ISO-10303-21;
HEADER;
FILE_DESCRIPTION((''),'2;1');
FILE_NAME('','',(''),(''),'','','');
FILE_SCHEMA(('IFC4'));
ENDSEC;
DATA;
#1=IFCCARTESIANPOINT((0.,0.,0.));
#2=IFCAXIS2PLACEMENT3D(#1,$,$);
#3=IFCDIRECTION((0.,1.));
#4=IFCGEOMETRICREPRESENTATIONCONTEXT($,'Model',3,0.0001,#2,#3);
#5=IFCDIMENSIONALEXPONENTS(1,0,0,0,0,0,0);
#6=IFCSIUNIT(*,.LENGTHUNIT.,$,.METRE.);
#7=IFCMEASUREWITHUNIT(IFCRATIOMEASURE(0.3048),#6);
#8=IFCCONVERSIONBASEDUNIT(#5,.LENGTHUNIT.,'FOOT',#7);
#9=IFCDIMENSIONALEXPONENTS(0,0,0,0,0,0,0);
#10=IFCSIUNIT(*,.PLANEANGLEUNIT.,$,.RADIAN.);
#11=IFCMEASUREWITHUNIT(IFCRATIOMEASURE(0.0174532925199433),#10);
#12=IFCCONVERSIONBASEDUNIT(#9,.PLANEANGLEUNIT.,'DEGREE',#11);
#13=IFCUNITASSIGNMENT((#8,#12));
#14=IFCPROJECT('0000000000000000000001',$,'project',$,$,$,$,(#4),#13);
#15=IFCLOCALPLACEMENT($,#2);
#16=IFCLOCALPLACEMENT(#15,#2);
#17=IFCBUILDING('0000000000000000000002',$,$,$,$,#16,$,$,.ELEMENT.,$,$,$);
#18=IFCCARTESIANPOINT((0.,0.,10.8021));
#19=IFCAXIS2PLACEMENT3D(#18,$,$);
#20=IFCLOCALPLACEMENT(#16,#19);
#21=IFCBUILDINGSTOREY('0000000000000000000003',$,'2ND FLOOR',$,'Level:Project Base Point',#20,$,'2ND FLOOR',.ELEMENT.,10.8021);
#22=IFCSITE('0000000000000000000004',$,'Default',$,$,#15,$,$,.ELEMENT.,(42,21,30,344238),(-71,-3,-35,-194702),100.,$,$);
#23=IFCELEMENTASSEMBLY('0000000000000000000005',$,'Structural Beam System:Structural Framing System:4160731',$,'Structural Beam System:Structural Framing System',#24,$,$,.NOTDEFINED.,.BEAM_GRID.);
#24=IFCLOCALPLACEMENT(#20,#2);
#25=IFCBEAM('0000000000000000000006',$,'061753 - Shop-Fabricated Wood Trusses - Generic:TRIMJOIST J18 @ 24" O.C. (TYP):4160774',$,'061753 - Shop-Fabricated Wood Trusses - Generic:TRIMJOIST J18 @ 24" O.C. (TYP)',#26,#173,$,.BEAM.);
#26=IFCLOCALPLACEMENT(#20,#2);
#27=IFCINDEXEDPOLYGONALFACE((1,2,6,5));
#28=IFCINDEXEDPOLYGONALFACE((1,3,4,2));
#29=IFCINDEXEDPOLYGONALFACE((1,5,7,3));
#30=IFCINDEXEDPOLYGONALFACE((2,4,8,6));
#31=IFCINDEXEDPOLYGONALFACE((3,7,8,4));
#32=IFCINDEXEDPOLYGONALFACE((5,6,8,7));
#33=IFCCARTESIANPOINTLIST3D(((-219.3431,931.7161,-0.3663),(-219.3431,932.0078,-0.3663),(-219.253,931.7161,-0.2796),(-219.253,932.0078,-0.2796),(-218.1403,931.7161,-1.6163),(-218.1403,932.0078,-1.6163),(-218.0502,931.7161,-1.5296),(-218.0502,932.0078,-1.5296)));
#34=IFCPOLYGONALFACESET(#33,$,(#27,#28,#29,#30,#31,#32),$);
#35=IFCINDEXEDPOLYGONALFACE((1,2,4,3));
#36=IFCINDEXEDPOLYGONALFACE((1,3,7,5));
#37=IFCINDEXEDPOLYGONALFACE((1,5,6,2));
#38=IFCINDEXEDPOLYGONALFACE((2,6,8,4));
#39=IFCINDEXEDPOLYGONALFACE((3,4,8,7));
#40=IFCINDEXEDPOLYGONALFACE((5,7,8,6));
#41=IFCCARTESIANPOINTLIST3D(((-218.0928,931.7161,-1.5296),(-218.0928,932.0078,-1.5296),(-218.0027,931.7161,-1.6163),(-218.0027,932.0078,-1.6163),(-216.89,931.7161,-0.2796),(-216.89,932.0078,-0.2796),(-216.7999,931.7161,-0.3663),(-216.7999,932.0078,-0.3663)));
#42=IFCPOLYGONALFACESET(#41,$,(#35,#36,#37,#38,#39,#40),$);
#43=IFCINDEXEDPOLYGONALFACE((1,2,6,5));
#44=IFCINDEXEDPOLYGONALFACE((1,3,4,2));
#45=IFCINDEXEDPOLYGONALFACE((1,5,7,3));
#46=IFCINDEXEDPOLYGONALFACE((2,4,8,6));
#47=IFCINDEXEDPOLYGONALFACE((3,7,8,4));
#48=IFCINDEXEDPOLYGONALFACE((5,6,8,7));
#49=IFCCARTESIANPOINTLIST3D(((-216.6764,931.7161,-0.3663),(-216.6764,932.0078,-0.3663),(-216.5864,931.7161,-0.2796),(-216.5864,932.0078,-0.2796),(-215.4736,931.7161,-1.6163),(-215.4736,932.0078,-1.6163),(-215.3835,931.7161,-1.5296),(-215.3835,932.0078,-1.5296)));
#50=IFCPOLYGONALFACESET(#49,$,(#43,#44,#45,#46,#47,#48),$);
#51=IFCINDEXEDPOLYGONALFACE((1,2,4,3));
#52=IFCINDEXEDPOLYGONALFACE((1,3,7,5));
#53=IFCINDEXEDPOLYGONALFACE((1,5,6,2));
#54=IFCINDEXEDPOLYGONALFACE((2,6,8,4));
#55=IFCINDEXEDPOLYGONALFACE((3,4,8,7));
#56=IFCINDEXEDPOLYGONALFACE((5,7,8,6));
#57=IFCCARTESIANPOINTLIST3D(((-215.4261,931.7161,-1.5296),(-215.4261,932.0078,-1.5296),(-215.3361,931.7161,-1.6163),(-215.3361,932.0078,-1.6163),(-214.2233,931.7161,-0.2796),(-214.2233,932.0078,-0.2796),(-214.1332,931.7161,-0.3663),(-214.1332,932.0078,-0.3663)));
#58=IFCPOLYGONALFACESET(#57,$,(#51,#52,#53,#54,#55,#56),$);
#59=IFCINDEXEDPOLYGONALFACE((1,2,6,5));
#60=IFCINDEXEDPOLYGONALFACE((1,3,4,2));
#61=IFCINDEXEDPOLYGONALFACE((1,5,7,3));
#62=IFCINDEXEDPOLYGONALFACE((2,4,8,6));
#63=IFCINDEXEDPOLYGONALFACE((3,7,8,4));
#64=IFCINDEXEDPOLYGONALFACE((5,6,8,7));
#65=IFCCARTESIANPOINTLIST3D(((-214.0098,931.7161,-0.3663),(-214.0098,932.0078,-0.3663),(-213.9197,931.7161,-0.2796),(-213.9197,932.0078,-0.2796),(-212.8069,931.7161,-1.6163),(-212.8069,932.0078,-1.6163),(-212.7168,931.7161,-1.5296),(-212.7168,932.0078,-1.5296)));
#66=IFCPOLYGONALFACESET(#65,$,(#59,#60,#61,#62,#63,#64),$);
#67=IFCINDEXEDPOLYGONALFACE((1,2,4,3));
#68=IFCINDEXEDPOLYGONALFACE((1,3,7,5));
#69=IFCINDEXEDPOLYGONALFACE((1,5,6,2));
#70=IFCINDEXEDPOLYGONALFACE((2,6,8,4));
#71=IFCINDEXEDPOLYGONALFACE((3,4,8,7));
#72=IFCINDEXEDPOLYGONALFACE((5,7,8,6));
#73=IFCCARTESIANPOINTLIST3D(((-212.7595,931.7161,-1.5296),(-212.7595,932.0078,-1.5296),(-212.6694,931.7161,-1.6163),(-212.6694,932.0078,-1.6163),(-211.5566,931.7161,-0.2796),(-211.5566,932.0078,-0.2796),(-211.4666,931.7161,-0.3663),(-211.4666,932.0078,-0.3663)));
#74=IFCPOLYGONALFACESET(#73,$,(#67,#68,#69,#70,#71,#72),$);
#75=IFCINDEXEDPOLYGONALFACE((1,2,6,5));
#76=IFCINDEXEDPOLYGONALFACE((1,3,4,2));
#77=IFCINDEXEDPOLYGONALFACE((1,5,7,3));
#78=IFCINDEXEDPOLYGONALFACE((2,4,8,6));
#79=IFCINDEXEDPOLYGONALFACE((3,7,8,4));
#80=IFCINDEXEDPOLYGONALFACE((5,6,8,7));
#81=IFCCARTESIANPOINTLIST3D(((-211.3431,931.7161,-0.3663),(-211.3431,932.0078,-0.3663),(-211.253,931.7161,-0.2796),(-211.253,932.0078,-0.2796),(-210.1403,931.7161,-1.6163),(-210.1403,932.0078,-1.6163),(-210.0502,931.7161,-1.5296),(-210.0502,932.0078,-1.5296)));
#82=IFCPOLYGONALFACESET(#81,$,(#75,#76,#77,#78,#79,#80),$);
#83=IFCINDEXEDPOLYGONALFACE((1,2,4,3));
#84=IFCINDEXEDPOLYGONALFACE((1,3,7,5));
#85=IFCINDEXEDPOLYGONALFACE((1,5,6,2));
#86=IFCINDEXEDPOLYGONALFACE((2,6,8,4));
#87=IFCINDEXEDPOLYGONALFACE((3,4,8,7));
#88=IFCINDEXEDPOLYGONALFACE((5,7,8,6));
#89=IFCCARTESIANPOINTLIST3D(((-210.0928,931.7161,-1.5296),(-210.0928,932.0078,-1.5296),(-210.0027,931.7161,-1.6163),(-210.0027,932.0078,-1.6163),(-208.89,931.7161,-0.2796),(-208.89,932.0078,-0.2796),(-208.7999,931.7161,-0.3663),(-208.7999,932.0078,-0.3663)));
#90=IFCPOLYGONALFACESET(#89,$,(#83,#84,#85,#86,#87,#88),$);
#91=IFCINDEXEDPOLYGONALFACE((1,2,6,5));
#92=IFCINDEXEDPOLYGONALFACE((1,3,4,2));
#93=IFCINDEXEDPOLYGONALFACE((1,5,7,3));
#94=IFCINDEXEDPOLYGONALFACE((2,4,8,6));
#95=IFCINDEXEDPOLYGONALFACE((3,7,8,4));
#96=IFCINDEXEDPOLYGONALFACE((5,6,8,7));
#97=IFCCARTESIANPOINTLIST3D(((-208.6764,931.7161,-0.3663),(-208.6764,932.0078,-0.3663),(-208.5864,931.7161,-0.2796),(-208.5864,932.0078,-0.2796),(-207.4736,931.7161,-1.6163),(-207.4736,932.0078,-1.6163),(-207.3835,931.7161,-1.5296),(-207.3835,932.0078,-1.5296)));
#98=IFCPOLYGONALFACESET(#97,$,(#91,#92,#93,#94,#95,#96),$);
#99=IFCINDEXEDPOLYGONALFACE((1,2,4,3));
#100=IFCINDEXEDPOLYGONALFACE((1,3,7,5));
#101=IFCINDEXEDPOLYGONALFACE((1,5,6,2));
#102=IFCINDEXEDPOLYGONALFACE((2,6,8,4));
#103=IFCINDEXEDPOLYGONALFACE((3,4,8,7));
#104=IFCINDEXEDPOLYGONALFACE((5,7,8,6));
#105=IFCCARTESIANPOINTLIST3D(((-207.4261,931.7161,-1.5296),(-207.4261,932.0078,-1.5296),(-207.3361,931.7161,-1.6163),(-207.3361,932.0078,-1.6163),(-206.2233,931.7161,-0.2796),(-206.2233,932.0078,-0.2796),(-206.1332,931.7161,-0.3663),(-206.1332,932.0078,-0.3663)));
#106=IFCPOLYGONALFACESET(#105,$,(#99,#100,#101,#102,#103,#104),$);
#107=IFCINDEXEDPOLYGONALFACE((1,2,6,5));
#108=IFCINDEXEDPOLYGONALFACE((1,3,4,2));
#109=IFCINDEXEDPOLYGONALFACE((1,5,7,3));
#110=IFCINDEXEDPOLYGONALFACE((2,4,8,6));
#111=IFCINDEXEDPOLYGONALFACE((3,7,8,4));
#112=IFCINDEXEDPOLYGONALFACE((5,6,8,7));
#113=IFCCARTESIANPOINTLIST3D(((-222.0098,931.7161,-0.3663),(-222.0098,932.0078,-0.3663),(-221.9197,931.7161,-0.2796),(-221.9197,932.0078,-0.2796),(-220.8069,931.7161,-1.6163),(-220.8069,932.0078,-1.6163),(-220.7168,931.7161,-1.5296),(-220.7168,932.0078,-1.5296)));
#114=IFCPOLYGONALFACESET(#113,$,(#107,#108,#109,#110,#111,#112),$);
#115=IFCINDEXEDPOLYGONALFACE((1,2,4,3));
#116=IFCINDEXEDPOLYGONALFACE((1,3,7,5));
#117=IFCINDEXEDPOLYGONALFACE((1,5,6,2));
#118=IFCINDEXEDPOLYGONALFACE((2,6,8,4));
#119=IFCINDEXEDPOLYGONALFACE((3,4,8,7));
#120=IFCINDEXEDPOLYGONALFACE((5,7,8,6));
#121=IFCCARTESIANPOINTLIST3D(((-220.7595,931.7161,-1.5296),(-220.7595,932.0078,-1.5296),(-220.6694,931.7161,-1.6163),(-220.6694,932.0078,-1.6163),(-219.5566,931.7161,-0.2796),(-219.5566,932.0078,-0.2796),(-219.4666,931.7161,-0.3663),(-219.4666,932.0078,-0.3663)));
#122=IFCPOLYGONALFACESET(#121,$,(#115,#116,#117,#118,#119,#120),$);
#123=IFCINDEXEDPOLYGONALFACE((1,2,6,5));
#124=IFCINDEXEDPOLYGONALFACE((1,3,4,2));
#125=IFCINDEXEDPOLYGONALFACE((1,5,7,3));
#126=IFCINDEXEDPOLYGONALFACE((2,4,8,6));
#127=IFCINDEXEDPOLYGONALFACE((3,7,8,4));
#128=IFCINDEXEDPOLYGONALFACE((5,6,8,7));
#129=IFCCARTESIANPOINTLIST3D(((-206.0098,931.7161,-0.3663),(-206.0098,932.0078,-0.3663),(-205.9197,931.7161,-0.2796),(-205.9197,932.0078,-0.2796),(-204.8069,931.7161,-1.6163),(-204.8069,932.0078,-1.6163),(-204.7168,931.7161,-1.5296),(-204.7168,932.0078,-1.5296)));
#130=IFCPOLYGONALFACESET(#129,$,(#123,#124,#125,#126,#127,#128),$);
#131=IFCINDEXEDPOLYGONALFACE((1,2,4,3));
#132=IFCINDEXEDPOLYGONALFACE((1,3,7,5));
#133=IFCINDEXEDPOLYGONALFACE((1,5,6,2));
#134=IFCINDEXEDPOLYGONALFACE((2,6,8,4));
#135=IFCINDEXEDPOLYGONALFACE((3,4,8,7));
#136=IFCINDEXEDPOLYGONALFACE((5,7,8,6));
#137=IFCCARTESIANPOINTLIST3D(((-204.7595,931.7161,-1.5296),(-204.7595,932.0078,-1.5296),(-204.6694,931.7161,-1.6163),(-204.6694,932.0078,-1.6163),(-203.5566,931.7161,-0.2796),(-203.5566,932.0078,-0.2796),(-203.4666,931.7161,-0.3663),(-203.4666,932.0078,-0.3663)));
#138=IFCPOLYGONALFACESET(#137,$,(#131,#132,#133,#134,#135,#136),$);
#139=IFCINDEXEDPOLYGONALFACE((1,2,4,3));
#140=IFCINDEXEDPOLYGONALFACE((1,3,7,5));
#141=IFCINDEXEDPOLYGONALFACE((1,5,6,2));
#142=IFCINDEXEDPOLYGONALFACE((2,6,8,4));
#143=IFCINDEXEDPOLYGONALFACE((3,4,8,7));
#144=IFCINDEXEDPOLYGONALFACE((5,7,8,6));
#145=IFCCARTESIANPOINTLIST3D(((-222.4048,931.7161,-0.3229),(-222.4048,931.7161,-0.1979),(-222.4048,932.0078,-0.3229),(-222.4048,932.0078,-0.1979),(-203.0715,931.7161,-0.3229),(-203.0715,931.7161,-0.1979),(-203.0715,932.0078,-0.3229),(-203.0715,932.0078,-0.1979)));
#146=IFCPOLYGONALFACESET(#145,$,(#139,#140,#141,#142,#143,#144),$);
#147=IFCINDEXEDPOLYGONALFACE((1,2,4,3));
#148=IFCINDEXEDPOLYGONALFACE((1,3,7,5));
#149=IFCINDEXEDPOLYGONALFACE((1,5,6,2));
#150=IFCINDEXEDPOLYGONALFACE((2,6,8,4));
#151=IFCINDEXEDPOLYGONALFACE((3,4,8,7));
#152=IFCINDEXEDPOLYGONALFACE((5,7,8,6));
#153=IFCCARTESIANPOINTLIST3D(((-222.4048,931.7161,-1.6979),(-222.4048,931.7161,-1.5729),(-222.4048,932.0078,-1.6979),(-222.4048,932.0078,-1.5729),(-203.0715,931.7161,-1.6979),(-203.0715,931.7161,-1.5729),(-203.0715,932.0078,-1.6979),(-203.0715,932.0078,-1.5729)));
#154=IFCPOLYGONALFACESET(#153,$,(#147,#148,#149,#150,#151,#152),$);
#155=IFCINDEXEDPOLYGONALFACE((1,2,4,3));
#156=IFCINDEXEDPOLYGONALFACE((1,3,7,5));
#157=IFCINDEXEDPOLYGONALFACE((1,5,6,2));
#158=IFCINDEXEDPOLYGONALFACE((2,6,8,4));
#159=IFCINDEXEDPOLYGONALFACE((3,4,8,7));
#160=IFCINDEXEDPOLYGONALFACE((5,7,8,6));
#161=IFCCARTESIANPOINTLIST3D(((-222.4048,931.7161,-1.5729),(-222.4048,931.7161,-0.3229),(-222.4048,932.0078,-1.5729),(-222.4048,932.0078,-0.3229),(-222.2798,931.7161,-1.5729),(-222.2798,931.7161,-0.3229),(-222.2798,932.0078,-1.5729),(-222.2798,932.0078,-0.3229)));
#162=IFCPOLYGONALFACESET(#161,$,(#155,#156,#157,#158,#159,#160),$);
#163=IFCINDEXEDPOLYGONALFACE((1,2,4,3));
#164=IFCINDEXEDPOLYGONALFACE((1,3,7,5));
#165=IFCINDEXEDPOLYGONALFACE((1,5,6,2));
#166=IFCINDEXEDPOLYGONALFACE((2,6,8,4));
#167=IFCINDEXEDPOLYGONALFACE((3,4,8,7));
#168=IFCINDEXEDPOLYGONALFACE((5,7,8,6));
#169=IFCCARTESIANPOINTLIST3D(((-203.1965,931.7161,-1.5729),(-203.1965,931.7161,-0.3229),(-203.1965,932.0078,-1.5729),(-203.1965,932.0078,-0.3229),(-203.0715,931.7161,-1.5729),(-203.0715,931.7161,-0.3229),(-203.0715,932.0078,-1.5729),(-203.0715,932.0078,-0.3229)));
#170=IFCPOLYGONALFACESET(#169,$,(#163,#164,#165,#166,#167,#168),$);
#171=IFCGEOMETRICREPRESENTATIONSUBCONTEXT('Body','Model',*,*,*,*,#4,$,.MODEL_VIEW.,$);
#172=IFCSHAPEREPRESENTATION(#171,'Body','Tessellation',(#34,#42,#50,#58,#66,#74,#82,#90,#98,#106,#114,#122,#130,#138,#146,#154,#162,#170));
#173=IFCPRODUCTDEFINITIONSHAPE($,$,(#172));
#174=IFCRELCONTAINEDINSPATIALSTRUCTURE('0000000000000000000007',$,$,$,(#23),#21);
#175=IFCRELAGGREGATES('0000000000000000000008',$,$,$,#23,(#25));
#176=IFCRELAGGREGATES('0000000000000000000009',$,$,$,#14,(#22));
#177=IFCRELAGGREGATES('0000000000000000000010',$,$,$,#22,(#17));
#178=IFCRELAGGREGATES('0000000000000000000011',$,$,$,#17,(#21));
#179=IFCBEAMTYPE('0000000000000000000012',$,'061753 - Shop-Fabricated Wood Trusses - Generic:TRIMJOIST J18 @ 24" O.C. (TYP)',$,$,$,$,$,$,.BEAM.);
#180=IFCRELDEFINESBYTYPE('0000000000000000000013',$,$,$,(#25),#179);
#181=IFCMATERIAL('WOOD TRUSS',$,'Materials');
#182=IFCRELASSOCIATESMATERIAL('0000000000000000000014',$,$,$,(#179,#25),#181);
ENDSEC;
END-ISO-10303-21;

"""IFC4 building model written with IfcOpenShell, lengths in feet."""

from ifc_helpers import new_model, entity, si_unit, converted_unit, direction, frame, frame_2d, origin, origin_2d_with_axis, place, context, subcontext, project, spatial, rectangle, extrude, source, transform, mapped, material, material_profile, profile_set, profile_usage, type_object, type_shapes, element, aggregate, save


model = new_model("IFC4")

# Units and contexts
model_context = context("Model", 3, precision=0.0001, world=origin(), true_north=direction((0.0, 1.0)))
body_context = subcontext(model_context, "Body", "Model", "MODEL_VIEW")
ifc_project = project(units=[converted_unit("LENGTHUNIT", "FOOT", entity("IfcRatioMeasure", 0.3048), si_unit("LENGTHUNIT", "METRE"), dimensions=[1, 0, 0, 0, 0, 0, 0]), converted_unit("PLANEANGLEUNIT", "DEGREE", entity("IfcRatioMeasure", 0.0174532925199433), si_unit("PLANEANGLEUNIT", "RADIAN"), dimensions=[0, 0, 0, 0, 0, 0, 0])], contexts=[model_context])

# Site, building, storey
site_placement = place(None, origin())
site = spatial("IfcSite", under=ifc_project, at=site_placement, Name="Default", CompositionType="ELEMENT", RefLatitude=(42, 21, 30, 344238), RefLongitude=(-71, -3, -35, -194702), RefElevation=100.0)
building_placement = place(site_placement, origin())
building = spatial("IfcBuilding", under=site, at=building_placement, CompositionType="ELEMENT")
storey_placement = place(building_placement, frame((0.0, 0.0, 10.8021)))
storey = spatial("IfcBuildingStorey", under=building, at=storey_placement, Name="2ND FLOOR", ObjectType="Level:Project Base Point", LongName="2ND FLOOR", CompositionType="ELEMENT", Elevation=10.8021)

# Element assembly, beam
ifc_material_1 = material(Name="WOOD TRUSS", Category="Materials")
ifc_material_profile_1 = material_profile(ifc_material_1, rectangle(XDim=1.7347, YDim=0.125, at=frame_2d((0.0, 0.0), x_axis=(1.0, 0.0))), Name="TRIMJOIST J18 @ 24\" O.C. (TYP)")
ifc_material_profile_2 = material_profile(ifc_material_1, rectangle(XDim=1.7347, YDim=0.125, at=frame_2d((0.0, 0.0), x_axis=(1.0, 0.0))), Name="TRIMJOIST J18 @ 24\" O.C. (TYP)")
ifc_material_profile_3 = material_profile(ifc_material_1, rectangle(XDim=1.7347, YDim=0.125, at=frame_2d((0.0, 0.0), x_axis=(1.0, 0.0))), Name="TRIMJOIST J18 @ 24\" O.C. (TYP)")
ifc_material_profile_4 = material_profile(ifc_material_1, rectangle(XDim=1.7347, YDim=0.125, at=frame_2d((0.0, 0.0), x_axis=(1.0, 0.0))), Name="TRIMJOIST J18 @ 24\" O.C. (TYP)")
ifc_material_profile_5 = material_profile(ifc_material_1, rectangle(XDim=1.7347, YDim=0.125, at=frame_2d((0.0, 0.0), x_axis=(1.0, 0.0))), Name="TRIMJOIST J18 @ 24\" O.C. (TYP)")
ifc_material_profile_6 = material_profile(ifc_material_1, rectangle(XDim=1.7347, YDim=0.125, at=frame_2d((0.0, 0.0), x_axis=(1.0, 0.0))), Name="TRIMJOIST J18 @ 24\" O.C. (TYP)")
ifc_material_profile_7 = material_profile(ifc_material_1, rectangle(XDim=1.7347, YDim=0.125, at=frame_2d((0.0, 0.0), x_axis=(1.0, 0.0))), Name="TRIMJOIST J18 @ 24\" O.C. (TYP)")
ifc_material_profile_8 = material_profile(ifc_material_1, rectangle(XDim=1.7347, YDim=0.125, at=frame_2d((0.0, 0.0), x_axis=(1.0, 0.0))), Name="TRIMJOIST J18 @ 24\" O.C. (TYP)")
ifc_material_profile_9 = material_profile(ifc_material_1, rectangle(XDim=1.7347, YDim=0.125, at=frame_2d((0.0, 0.0), x_axis=(1.0, 0.0))), Name="TRIMJOIST J18 @ 24\" O.C. (TYP)")
ifc_material_profile_10 = material_profile(ifc_material_1, rectangle(XDim=1.7347, YDim=0.125, at=origin_2d_with_axis()), Name="TRIMJOIST J18 @ 24\" O.C. (TYP)")
ifc_material_profile_11 = material_profile(ifc_material_1, rectangle(XDim=0.125, YDim=0.2917, at=origin_2d_with_axis()), Name="TRIMJOIST J18 @ 24\" O.C. (TYP)")
ifc_material_profile_12 = material_profile(ifc_material_1, rectangle(XDim=0.125, YDim=0.2917, at=origin_2d_with_axis()), Name="TRIMJOIST J18 @ 24\" O.C. (TYP)")
ifc_material_profile_13 = material_profile(ifc_material_1, rectangle(XDim=1.25, YDim=0.2917, at=origin_2d_with_axis()), Name="TRIMJOIST J18 @ 24\" O.C. (TYP)")
ifc_material_profile_14 = material_profile(ifc_material_1, rectangle(XDim=1.25, YDim=0.2917, at=origin_2d_with_axis()), Name="TRIMJOIST J18 @ 24\" O.C. (TYP)")
ifc_profile_set_1 = profile_set([ifc_material_profile_1, ifc_material_profile_2, ifc_material_profile_3, ifc_material_profile_4, ifc_material_profile_5, ifc_material_profile_6, ifc_material_profile_7, ifc_material_profile_8, ifc_material_profile_9, ifc_material_profile_10, ifc_material_profile_11, ifc_material_profile_12, ifc_material_profile_13, ifc_material_profile_14], Name="TRIMJOIST J18 @ 24\" O.C. (TYP)")
beam_type_1 = type_object("IfcBeamType", Name="061753 - Shop-Fabricated Wood Trusses - Generic:TRIMJOIST J18 @ 24\" O.C. (TYP)", PredefinedType="BEAM", material=ifc_profile_set_1)
shared_shape_1 = source(origin(), body_context, "Body", "SweptSolid", [
    extrude(rectangle(XDim=1.7347, YDim=0.125, at=frame_2d((0.0, 0.0), x_axis=(1.0, 0.0))), frame((5.9585, -0.1458, 0.0), z_axis=(0.0, 1.0, 0.0), x_axis=(0.693383, 0.0, 0.720569)), (0.0, 0.0, 1.0), 0.2917),
    extrude(rectangle(XDim=1.7347, YDim=0.125, at=origin_2d_with_axis()), frame((4.7082, -0.1458, 0.0), z_axis=(0.0, 1.0, 0.0), x_axis=(0.693383, 0.0, -0.720569)), (0.0, 0.0, 1.0), 0.2917),
    extrude(rectangle(XDim=1.7347, YDim=0.125, at=frame_2d((0.0, 0.0), x_axis=(1.0, 0.0))), frame((3.2918, -0.1458, 0.0), z_axis=(0.0, 1.0, 0.0), x_axis=(0.693383, 0.0, 0.720569)), (0.0, 0.0, 1.0), 0.2917),
    extrude(rectangle(XDim=1.7347, YDim=0.125, at=frame_2d((0.0, 0.0), x_axis=(1.0, 0.0))), frame((2.0415, -0.1458, 0.0), z_axis=(0.0, 1.0, 0.0), x_axis=(0.693383, 0.0, -0.720569)), (0.0, 0.0, 1.0), 0.2917),
    extrude(rectangle(XDim=1.7347, YDim=0.125, at=frame_2d((0.0, 0.0), x_axis=(1.0, 0.0))), frame((0.6251, -0.1458, 0.0), z_axis=(0.0, 1.0, 0.0), x_axis=(0.693383, 0.0, 0.720569)), (0.0, 0.0, 1.0), 0.2917),
    extrude(rectangle(XDim=1.7347, YDim=0.125, at=frame_2d((0.0, 0.0), x_axis=(1.0, 0.0))), frame((-0.6251, -0.1458, 0.0), z_axis=(0.0, 1.0, 0.0), x_axis=(0.693383, 0.0, -0.720569)), (0.0, 0.0, 1.0), 0.2917),
    extrude(rectangle(XDim=1.7347, YDim=0.125, at=frame_2d((0.0, 0.0), x_axis=(1.0, 0.0))), frame((-2.0415, -0.1458, 0.0), z_axis=(0.0, 1.0, 0.0), x_axis=(0.693383, 0.0, 0.720569)), (0.0, 0.0, 1.0), 0.2917),
    extrude(rectangle(XDim=1.7347, YDim=0.125, at=origin_2d_with_axis()), frame((-3.2918, -0.1458, 0.0), z_axis=(0.0, 1.0, 0.0), x_axis=(0.693383, 0.0, -0.720569)), (0.0, 0.0, 1.0), 0.2917),
    extrude(rectangle(XDim=1.7347, YDim=0.125, at=frame_2d((0.0, 0.0), x_axis=(1.0, 0.0))), frame((-4.7082, -0.1458, 0.0), z_axis=(0.0, 1.0, 0.0), x_axis=(0.693383, 0.0, 0.720569)), (0.0, 0.0, 1.0), 0.2917),
    extrude(rectangle(XDim=1.7347, YDim=0.125, at=frame_2d((0.0, 0.0), x_axis=(1.0, 0.0))), frame((-5.9585, -0.1458, 0.0), z_axis=(0.0, 1.0, 0.0), x_axis=(0.693383, 0.0, -0.720569)), (0.0, 0.0, 1.0), 0.2917),
    extrude(rectangle(XDim=1.7347, YDim=0.125, at=frame_2d((0.0, 0.0), x_axis=(1.0, 0.0))), frame((8.6251, -0.1458, 0.0), z_axis=(0.0, 1.0, 0.0), x_axis=(0.693383, 0.0, 0.720569)), (0.0, 0.0, 1.0), 0.2917),
    extrude(rectangle(XDim=1.7347, YDim=0.125, at=origin_2d_with_axis()), frame((7.3749, -0.1458, 0.0), z_axis=(0.0, 1.0, 0.0), x_axis=(0.693383, 0.0, -0.720569)), (0.0, 0.0, 1.0), 0.2917),
    extrude(rectangle(XDim=1.7347, YDim=0.125, at=frame_2d((0.0, 0.0), x_axis=(1.0, 0.0))), frame((-7.3749, -0.1458, 0.0), z_axis=(0.0, 1.0, 0.0), x_axis=(0.693383, 0.0, 0.720569)), (0.0, 0.0, 1.0), 0.2917),
    extrude(rectangle(XDim=1.7347, YDim=0.125, at=origin_2d_with_axis()), frame((-8.6251, -0.1458, 0.0), z_axis=(0.0, 1.0, 0.0), x_axis=(0.693383, 0.0, -0.720569)), (0.0, 0.0, 1.0), 0.2917),
    extrude(rectangle(XDim=0.125, YDim=0.2917, at=origin_2d_with_axis()), frame((-9.6667, 0.0, 0.6875), z_axis=(1.0, 0.0, 0.0), x_axis=(0.0, 0.0, -1.0)), (0.0, 0.0, 1.0), 19.3333),
    extrude(rectangle(XDim=0.125, YDim=0.2917, at=origin_2d_with_axis()), frame((-9.6667, 0.0, -0.6875), z_axis=(1.0, 0.0, 0.0), x_axis=(0.0, 0.0, -1.0)), (0.0, 0.0, 1.0), 19.3333),
    extrude(rectangle(XDim=1.25, YDim=0.2917, at=origin_2d_with_axis()), frame((9.5417, 0.0, 0.0), z_axis=(1.0, 0.0, 0.0), x_axis=(0.0, 0.0, -1.0)), (0.0, 0.0, 1.0), 0.125),
    extrude(rectangle(XDim=1.25, YDim=0.2917, at=origin_2d_with_axis()), frame((-9.6667, 0.0, 0.0), z_axis=(1.0, 0.0, 0.0), x_axis=(0.0, 0.0, -1.0)), (0.0, 0.0, 1.0), 0.125),
])
type_shapes(beam_type_1, [shared_shape_1])
assembly_1_placement = place(storey_placement, origin())
assembly_1 = element("IfcElementAssembly", 1, at=assembly_1_placement, inside=storey, Name="Structural Beam System:Structural Framing System:4160731", ObjectType="Structural Beam System:Structural Framing System", AssemblyPlace="NOTDEFINED", PredefinedType="BEAM_GRID")
ifc_profile_usage_1 = profile_usage(ifc_profile_set_1, cardinal=8)
beam_1_placement = place(assembly_1_placement, frame((-212.7382, 931.8619, -0.9479), z_axis=(0.0, 0.0, 1.0), x_axis=(-1.0, 0.0, 0.0)))
beam_1 = element("IfcBeam", 2, at=beam_1_placement, type_object=beam_type_1, material=ifc_profile_usage_1, Name="061753 - Shop-Fabricated Wood Trusses - Generic:TRIMJOIST J18 @ 24\" O.C. (TYP):4160774", ObjectType="061753 - Shop-Fabricated Wood Trusses - Generic:TRIMJOIST J18 @ 24\" O.C. (TYP)", PredefinedType="BEAM", context=body_context, shape_type="MappedRepresentation", body=[
    mapped(shared_shape_1, transform((0.0, 0.0, 0.0), scale=1.0)),
])
aggregate(assembly_1, [beam_1])

save(model, "model.ifc")
